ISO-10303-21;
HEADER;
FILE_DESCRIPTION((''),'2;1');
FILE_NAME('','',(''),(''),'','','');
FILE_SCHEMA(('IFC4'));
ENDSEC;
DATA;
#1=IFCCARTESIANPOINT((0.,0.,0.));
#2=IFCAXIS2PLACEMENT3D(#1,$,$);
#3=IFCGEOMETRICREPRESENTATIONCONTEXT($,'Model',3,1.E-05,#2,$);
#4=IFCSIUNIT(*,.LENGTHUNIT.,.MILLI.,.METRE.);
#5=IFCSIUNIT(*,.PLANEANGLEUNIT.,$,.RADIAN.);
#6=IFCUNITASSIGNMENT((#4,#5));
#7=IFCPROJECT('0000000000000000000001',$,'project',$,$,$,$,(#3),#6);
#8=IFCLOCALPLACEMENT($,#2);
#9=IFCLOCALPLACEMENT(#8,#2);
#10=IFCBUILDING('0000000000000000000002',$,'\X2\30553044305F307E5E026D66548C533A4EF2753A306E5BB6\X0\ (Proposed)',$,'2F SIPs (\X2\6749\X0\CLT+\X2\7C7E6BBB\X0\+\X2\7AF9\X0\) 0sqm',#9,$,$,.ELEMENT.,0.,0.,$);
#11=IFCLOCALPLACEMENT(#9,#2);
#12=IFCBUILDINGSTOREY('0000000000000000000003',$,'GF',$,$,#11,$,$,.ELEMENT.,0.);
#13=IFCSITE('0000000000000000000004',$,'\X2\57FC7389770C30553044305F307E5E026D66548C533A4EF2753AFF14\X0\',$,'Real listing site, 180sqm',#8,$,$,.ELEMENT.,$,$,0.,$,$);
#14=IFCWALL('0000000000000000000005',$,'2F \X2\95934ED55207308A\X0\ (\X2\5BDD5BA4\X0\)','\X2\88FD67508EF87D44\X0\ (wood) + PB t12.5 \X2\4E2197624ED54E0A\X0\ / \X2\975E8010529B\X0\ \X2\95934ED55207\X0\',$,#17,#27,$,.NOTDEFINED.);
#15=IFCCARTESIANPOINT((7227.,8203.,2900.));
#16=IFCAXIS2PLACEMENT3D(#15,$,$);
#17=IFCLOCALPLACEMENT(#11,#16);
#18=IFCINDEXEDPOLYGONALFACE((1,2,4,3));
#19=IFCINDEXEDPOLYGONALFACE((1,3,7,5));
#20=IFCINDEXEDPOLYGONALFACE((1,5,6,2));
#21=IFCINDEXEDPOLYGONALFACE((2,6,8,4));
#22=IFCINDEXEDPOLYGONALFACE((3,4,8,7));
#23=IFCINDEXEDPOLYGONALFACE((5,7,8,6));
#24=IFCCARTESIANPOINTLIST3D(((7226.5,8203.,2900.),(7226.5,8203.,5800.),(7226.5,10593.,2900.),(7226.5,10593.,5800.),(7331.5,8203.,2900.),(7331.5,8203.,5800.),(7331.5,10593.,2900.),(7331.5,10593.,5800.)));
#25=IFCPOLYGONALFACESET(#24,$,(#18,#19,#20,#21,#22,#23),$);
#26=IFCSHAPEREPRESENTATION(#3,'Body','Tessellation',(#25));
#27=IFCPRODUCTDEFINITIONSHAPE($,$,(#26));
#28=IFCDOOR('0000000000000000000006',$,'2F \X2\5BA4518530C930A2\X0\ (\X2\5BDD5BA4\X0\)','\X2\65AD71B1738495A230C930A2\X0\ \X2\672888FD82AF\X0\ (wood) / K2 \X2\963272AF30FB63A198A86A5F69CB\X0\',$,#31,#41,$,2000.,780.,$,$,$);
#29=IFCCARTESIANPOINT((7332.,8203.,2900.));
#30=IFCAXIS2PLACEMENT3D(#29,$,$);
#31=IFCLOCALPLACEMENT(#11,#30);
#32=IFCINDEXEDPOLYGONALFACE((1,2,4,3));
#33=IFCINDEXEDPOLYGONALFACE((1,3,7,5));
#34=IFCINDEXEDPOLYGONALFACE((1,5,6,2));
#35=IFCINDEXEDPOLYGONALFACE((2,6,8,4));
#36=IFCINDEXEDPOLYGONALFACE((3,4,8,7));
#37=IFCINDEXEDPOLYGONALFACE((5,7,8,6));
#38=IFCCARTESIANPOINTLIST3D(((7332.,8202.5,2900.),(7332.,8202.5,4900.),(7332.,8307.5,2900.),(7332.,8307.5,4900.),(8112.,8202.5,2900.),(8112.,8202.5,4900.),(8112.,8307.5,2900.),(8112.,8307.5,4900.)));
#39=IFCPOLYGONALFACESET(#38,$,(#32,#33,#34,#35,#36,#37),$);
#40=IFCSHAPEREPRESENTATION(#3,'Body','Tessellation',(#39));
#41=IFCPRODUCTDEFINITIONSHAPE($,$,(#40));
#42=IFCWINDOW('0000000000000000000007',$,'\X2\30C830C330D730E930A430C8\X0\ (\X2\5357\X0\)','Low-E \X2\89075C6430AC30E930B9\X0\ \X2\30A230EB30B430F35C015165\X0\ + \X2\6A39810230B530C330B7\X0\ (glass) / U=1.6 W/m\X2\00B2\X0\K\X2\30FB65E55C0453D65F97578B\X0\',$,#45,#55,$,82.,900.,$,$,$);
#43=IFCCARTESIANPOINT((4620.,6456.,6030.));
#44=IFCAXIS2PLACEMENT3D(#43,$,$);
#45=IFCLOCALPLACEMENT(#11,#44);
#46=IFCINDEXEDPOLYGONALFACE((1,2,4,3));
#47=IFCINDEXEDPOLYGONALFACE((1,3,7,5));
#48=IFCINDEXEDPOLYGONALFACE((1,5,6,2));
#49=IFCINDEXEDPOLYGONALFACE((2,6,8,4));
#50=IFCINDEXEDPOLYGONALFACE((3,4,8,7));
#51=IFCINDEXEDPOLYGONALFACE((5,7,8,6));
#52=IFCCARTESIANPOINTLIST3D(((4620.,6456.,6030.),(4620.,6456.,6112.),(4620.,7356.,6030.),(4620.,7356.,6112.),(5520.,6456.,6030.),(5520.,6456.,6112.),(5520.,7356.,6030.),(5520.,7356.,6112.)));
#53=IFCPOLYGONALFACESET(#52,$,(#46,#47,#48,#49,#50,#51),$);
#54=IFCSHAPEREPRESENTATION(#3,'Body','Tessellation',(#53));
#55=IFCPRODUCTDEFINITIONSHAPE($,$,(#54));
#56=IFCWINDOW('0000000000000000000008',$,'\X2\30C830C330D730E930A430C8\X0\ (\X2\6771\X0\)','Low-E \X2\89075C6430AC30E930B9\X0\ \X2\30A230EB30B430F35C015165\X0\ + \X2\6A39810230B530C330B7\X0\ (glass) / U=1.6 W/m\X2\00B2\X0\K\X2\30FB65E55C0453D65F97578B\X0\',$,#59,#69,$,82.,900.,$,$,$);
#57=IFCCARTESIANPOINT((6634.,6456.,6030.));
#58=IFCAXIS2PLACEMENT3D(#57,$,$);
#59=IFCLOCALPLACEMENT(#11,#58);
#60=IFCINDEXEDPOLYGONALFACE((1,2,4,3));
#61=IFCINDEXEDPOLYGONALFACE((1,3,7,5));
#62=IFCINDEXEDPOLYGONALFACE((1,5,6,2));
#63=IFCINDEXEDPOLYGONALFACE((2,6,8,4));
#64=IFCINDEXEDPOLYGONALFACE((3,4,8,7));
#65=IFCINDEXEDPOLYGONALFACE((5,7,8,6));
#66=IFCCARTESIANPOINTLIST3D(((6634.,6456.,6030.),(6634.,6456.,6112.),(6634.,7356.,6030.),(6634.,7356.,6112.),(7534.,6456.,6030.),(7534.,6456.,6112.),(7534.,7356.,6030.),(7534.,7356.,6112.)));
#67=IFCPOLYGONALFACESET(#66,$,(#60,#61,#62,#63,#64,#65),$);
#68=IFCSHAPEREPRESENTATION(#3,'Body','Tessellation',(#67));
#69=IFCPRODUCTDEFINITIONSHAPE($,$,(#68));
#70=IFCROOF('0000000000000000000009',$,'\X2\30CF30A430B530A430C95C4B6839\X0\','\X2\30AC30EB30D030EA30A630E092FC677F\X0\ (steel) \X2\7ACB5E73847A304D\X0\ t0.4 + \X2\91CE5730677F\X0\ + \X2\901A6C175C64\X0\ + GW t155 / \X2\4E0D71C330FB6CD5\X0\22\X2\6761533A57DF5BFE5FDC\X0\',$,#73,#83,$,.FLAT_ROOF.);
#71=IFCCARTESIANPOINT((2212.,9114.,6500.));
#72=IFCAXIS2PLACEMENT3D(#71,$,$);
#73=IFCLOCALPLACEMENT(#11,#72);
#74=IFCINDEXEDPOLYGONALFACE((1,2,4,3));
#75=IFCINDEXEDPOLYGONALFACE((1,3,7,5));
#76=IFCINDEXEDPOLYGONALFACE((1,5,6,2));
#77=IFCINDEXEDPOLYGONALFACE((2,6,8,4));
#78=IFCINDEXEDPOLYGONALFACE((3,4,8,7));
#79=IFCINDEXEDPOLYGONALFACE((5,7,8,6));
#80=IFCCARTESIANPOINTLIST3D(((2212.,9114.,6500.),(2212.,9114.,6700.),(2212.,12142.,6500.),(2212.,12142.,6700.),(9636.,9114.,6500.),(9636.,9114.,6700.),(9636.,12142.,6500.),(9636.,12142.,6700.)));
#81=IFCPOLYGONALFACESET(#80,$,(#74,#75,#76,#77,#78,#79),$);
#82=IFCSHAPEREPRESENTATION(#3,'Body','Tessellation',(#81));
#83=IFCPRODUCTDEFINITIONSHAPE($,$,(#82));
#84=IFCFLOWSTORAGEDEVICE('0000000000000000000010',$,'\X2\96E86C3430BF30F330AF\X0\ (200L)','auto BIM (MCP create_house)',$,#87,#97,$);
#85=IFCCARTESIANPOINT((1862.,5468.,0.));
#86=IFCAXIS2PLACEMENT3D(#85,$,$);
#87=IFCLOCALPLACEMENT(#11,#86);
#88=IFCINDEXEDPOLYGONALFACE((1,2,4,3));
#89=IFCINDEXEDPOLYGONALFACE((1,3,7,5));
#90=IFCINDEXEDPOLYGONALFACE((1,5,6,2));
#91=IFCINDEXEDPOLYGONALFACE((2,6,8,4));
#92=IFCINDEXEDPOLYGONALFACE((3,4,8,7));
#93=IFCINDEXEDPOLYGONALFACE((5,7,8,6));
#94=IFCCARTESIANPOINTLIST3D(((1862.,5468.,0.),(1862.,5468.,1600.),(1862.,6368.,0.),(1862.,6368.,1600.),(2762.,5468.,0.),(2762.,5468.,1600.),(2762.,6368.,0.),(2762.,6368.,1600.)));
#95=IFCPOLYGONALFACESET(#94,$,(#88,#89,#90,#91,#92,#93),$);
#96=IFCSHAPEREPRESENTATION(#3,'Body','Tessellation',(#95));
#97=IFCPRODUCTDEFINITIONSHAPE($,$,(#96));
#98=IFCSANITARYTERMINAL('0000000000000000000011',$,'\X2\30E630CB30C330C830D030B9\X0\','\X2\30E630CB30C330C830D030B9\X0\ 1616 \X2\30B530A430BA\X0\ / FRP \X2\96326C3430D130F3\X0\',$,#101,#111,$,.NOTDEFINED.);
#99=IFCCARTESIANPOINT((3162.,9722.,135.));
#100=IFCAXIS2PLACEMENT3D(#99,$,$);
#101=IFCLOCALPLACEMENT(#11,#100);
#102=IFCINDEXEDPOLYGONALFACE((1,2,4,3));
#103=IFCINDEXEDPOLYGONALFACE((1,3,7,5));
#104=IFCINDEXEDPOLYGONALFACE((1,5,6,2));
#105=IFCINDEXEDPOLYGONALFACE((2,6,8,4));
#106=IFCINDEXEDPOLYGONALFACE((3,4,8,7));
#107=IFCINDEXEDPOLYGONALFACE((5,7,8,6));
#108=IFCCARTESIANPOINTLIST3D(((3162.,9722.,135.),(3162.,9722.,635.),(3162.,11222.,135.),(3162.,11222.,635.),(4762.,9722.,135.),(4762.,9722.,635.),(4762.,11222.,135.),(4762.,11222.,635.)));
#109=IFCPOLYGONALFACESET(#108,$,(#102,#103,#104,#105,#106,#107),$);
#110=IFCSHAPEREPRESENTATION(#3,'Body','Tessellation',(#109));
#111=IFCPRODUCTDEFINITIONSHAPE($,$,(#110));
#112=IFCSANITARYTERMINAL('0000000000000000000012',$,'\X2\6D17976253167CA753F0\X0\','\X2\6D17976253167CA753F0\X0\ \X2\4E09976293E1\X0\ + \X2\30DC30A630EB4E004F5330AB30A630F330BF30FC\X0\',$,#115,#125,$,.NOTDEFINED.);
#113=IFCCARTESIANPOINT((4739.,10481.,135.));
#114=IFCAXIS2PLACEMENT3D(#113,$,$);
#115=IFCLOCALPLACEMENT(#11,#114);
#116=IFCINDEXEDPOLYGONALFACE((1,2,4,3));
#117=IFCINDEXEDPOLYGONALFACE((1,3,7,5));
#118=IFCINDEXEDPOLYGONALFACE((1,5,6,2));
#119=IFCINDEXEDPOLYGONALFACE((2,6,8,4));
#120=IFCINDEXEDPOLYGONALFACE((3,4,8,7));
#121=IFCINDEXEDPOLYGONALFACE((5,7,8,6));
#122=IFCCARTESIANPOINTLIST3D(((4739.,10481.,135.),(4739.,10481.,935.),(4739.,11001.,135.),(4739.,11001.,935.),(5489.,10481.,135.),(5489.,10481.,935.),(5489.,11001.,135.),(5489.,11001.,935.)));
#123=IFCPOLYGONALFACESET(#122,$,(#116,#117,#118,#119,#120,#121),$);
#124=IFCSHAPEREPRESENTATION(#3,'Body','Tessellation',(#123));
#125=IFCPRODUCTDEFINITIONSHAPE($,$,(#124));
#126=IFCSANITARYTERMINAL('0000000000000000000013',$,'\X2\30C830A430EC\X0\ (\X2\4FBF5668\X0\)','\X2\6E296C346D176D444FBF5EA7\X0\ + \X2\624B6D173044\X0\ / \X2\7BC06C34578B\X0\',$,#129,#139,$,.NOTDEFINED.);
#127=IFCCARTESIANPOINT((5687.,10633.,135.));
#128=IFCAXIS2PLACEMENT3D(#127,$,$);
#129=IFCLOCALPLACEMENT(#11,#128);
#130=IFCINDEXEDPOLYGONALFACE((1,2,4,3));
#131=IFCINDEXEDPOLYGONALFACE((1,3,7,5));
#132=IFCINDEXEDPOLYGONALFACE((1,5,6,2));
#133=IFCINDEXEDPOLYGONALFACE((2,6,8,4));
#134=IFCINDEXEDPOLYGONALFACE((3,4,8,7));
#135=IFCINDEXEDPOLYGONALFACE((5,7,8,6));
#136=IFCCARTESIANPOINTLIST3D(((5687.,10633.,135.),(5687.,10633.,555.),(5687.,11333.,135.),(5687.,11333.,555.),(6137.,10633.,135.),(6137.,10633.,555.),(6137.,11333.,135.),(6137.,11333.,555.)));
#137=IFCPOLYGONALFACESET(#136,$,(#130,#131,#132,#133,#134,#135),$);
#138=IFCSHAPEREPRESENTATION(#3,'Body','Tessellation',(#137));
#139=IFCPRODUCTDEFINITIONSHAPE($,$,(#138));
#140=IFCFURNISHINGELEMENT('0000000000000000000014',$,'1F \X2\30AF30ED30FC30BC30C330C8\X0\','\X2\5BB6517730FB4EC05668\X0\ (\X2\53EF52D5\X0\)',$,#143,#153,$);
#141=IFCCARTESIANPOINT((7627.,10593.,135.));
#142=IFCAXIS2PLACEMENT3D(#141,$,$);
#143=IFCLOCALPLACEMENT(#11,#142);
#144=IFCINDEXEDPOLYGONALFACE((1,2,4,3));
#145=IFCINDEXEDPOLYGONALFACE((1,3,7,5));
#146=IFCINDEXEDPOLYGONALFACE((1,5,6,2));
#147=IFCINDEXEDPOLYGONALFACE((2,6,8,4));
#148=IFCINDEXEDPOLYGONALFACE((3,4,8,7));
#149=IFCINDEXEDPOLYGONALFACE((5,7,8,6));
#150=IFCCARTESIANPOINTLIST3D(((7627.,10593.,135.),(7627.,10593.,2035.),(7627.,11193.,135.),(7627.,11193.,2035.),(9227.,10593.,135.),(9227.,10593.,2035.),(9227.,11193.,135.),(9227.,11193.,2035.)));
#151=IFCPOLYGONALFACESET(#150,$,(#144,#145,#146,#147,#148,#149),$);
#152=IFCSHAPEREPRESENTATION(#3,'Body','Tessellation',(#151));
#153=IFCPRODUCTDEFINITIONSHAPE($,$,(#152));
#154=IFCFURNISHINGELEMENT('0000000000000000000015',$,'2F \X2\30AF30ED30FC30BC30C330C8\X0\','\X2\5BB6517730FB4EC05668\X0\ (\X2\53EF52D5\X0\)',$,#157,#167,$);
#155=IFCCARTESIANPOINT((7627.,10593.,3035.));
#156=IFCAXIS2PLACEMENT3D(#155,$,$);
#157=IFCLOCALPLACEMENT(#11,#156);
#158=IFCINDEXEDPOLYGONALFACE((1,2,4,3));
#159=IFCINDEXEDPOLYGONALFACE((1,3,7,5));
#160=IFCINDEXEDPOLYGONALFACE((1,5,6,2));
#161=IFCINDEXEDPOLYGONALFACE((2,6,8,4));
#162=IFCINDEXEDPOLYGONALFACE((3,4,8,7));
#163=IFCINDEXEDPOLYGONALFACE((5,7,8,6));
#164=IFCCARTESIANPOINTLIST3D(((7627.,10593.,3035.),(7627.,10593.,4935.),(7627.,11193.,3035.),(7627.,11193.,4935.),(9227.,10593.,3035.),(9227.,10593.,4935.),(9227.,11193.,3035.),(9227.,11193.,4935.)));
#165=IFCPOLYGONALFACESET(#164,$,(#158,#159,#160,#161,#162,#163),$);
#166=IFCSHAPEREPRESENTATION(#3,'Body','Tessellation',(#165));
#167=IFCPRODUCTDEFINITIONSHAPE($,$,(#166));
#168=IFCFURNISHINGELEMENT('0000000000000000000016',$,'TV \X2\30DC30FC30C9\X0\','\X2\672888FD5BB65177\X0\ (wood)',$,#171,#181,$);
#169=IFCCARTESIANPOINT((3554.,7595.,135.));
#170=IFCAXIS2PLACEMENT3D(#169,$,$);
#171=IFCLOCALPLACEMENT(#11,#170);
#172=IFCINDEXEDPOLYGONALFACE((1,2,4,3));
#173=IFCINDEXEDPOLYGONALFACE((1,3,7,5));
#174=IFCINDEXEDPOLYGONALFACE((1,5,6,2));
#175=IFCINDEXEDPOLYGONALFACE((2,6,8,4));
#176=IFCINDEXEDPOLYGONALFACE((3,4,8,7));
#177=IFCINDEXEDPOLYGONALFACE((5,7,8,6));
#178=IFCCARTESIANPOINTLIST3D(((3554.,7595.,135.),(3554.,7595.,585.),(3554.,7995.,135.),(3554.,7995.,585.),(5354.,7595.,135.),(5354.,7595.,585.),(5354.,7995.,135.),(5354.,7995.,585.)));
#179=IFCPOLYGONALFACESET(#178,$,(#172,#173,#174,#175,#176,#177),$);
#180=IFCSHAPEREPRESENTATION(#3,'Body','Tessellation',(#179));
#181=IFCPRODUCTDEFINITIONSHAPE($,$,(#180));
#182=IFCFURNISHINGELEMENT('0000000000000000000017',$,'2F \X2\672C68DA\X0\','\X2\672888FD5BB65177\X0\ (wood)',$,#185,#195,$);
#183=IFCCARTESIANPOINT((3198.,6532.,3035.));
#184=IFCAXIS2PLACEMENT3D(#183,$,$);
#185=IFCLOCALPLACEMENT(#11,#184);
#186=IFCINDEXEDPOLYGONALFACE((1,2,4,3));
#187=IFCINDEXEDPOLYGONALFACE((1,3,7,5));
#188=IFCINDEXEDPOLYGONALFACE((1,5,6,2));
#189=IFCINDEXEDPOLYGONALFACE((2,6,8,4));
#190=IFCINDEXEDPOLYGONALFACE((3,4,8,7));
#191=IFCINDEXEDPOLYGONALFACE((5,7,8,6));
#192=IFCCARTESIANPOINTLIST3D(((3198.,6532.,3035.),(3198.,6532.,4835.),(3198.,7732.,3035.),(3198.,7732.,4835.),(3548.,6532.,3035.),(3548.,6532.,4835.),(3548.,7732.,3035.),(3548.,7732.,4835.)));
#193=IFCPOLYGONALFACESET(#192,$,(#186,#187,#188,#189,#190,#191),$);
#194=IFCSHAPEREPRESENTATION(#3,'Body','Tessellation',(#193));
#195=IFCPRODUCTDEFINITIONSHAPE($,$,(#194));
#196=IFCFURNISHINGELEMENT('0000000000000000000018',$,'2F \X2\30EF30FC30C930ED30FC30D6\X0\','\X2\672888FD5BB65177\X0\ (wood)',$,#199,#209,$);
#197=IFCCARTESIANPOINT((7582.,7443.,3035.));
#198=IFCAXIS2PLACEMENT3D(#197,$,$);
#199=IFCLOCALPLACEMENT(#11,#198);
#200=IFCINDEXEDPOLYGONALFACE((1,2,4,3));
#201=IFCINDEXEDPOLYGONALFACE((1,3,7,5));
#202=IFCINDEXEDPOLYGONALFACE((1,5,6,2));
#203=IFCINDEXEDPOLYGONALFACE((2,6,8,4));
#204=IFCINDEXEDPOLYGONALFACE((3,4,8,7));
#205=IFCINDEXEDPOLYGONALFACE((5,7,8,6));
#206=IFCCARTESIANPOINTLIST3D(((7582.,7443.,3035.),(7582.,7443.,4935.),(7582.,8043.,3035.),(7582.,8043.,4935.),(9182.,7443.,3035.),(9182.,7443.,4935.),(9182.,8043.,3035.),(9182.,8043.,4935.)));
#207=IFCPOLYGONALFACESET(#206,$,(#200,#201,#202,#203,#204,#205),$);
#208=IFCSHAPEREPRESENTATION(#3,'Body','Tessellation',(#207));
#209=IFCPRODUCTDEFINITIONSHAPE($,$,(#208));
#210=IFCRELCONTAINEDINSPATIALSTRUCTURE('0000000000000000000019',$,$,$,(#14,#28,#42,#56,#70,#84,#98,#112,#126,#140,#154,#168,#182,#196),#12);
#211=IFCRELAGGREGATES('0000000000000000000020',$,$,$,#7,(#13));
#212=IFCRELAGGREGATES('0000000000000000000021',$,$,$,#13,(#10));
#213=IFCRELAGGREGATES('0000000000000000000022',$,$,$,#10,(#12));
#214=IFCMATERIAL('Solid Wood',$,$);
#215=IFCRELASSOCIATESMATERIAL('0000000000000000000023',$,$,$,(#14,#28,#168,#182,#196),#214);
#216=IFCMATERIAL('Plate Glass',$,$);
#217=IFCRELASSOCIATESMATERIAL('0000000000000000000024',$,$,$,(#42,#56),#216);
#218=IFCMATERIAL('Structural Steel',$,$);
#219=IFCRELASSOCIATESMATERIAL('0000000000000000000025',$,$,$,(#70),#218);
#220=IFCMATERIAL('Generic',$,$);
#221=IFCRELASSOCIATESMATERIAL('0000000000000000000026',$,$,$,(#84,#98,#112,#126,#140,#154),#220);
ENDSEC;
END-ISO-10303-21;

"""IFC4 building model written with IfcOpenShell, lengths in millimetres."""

from ifc_helpers import new_model, si_unit, frame, frame_2d, origin, place, context, project, spatial, rectangle, extrude, material, element, save


model = new_model("IFC4")

# Units and contexts
model_context = context("Model", 3, precision=1e-05, world=origin())
ifc_project = project(units=[si_unit("LENGTHUNIT", "METRE", prefix="MILLI"), si_unit("PLANEANGLEUNIT", "RADIAN")], contexts=[model_context])

# Site, building, storey
site_placement = place(None, origin())
site = spatial("IfcSite", under=ifc_project, at=site_placement, Name="埼玉県さいたま市浦和区仲町４", ObjectType="Real listing site, 180sqm", CompositionType="ELEMENT", RefElevation=0.0)
building_placement = place(site_placement, origin())
building = spatial("IfcBuilding", under=site, at=building_placement, Name="さいたま市浦和区仲町の家 (Proposed)", ObjectType="2F SIPs (杉CLT+籾殻+竹) 0sqm", CompositionType="ELEMENT", ElevationOfRefHeight=0.0, ElevationOfTerrain=0.0)
storey_placement = place(building_placement, origin())
storey = spatial("IfcBuildingStorey", under=building, at=storey_placement, Name="GF", CompositionType="ELEMENT", Elevation=0.0)

# Shared definitions
ifc_material_1 = material(Name="Solid Wood")
ifc_material_2 = material(Name="Plate Glass")

# Wall
wall_1_placement = place(storey_placement, frame((7227.0, 8203.0, 2900.0)))
element("IfcWall", 1, at=wall_1_placement, inside=storey, material=ifc_material_1, Name="2F 間仕切り (寝室)", Description="製材軸組 (wood) + PB t12.5 両面仕上 / 非耐力 間仕切", PredefinedType="NOTDEFINED", context=model_context, shape_type="SweptSolid", body=[
    extrude(rectangle(XDim=105.0, YDim=2390.0, at=frame_2d((52.0, 1195.0))), frame((7227.0, 8203.0, 2900.0)), (0.0, 0.0, 1.0), 2900.0),
])

# Door
door_1_placement = place(storey_placement, frame((7332.0, 8203.0, 2900.0)))
element("IfcDoor", 2, at=door_1_placement, inside=storey, material=ifc_material_1, Name="2F 室内ドア (寝室)", Description="断熱玄関ドア 木製芯 (wood) / K2 防犯・採風機構", OverallHeight=2000.0, OverallWidth=780.0, context=model_context, shape_type="SweptSolid", body=[
    extrude(rectangle(XDim=780.0, YDim=105.0, at=frame_2d((390.0, 52.0))), frame((7332.0, 8203.0, 2900.0)), (0.0, 0.0, 1.0), 2000.0),
])

# Windows
window_1_placement = place(storey_placement, frame((4620.0, 6456.0, 6030.0)))
element("IfcWindow", 3, at=window_1_placement, inside=storey, material=ifc_material_2, Name="トップライト (南)", Description="Low-E 複層ガラス アルゴン封入 + 樹脂サッシ (glass) / U=1.6 W/m²K・日射取得型", OverallHeight=82.0, OverallWidth=900.0, context=model_context, shape_type="SweptSolid", body=[
    extrude(rectangle(XDim=900.0, YDim=900.0, at=frame_2d((450.0, 450.0))), frame((4620.0, 6456.0, 6030.0)), (0.0, 0.0, 1.0), 82.0),
])
window_2_placement = place(storey_placement, frame((6634.0, 6456.0, 6030.0)))
element("IfcWindow", 4, at=window_2_placement, inside=storey, material=ifc_material_2, Name="トップライト (東)", Description="Low-E 複層ガラス アルゴン封入 + 樹脂サッシ (glass) / U=1.6 W/m²K・日射取得型", OverallHeight=82.0, OverallWidth=900.0, context=model_context, shape_type="SweptSolid", body=[
    extrude(rectangle(XDim=900.0, YDim=900.0, at=frame_2d((450.0, 450.0))), frame((6634.0, 6456.0, 6030.0)), (0.0, 0.0, 1.0), 82.0),
])

# Roof
ifc_material_3 = material(Name="Structural Steel")
roof_placement = place(storey_placement, frame((2212.0, 9114.0, 6500.0)))
element("IfcRoof", 5, at=roof_placement, inside=storey, material=ifc_material_3, Name="ハイサイド屋根", Description="ガルバリウム鋼板 (steel) 立平葺き t0.4 + 野地板 + 通気層 + GW t155 / 不燃・法22条区域対応", PredefinedType="FLAT_ROOF", context=model_context, shape_type="SweptSolid", body=[
    extrude(rectangle(XDim=7424.0, YDim=3028.0, at=frame_2d((3712.0, 1514.0))), frame((2212.0, 9114.0, 6500.0)), (0.0, 0.0, 1.0), 200.0),
])

# Flow storage device
ifc_material_4 = material(Name="Generic")
flow_storage_device_placement = place(storey_placement, frame((1862.0, 5468.0, 0.0)))
element("IfcFlowStorageDevice", 6, at=flow_storage_device_placement, inside=storey, material=ifc_material_4, Name="雨水タンク (200L)", Description="auto BIM (MCP create_house)", context=model_context, shape_type="SweptSolid", body=[
    extrude(rectangle(XDim=900.0, YDim=900.0, at=frame_2d((450.0, 450.0))), frame((1862.0, 5468.0, 0.0)), (0.0, 0.0, 1.0), 1600.0),
])

# Sanitary terminals
sanitary_terminal_1_placement = place(storey_placement, frame((3162.0, 9722.0, 135.0)))
element("IfcSanitaryTerminal", 7, at=sanitary_terminal_1_placement, inside=storey, material=ifc_material_4, Name="ユニットバス", Description="ユニットバス 1616 サイズ / FRP 防水パン", PredefinedType="NOTDEFINED", context=model_context, shape_type="SweptSolid", body=[
    extrude(rectangle(XDim=1600.0, YDim=1500.0, at=frame_2d((800.0, 750.0))), frame((3162.0, 9722.0, 135.0)), (0.0, 0.0, 1.0), 500.0),
])
sanitary_terminal_2_placement = place(storey_placement, frame((4739.0, 10481.0, 135.0)))
element("IfcSanitaryTerminal", 8, at=sanitary_terminal_2_placement, inside=storey, material=ifc_material_4, Name="洗面化粧台", Description="洗面化粧台 三面鏡 + ボウル一体カウンター", PredefinedType="NOTDEFINED", context=model_context, shape_type="SweptSolid", body=[
    extrude(rectangle(XDim=750.0, YDim=520.0, at=frame_2d((375.0, 260.0))), frame((4739.0, 10481.0, 135.0)), (0.0, 0.0, 1.0), 800.0),
])
sanitary_terminal_3_placement = place(storey_placement, frame((5687.0, 10633.0, 135.0)))
element("IfcSanitaryTerminal", 9, at=sanitary_terminal_3_placement, inside=storey, material=ifc_material_4, Name="トイレ (便器)", Description="温水洗浄便座 + 手洗い / 節水型", PredefinedType="NOTDEFINED", context=model_context, shape_type="SweptSolid", body=[
    extrude(rectangle(XDim=450.0, YDim=700.0, at=frame_2d((225.0, 350.0))), frame((5687.0, 10633.0, 135.0)), (0.0, 0.0, 1.0), 420.0),
])

# Furnishing elements
furnishing_1_placement = place(storey_placement, frame((7627.0, 10593.0, 135.0)))
element("IfcFurnishingElement", 10, at=furnishing_1_placement, inside=storey, material=ifc_material_4, Name="1F クローゼット", Description="家具・什器 (可動)", context=model_context, shape_type="SweptSolid", body=[
    extrude(rectangle(XDim=1600.0, YDim=600.0, at=frame_2d((800.0, 300.0))), frame((7627.0, 10593.0, 135.0)), (0.0, 0.0, 1.0), 1900.0),
])
furnishing_2_placement = place(storey_placement, frame((7627.0, 10593.0, 3035.0)))
element("IfcFurnishingElement", 11, at=furnishing_2_placement, inside=storey, material=ifc_material_4, Name="2F クローゼット", Description="家具・什器 (可動)", context=model_context, shape_type="SweptSolid", body=[
    extrude(rectangle(XDim=1600.0, YDim=600.0, at=frame_2d((800.0, 300.0))), frame((7627.0, 10593.0, 3035.0)), (0.0, 0.0, 1.0), 1900.0),
])
furnishing_3_placement = place(storey_placement, frame((3554.0, 7595.0, 135.0)))
element("IfcFurnishingElement", 12, at=furnishing_3_placement, inside=storey, material=ifc_material_1, Name="TV ボード", Description="木製家具 (wood)", context=model_context, shape_type="SweptSolid", body=[
    extrude(rectangle(XDim=1800.0, YDim=400.0, at=frame_2d((900.0, 200.0))), frame((3554.0, 7595.0, 135.0)), (0.0, 0.0, 1.0), 450.0),
])
furnishing_4_placement = place(storey_placement, frame((3198.0, 6532.0, 3035.0)))
element("IfcFurnishingElement", 13, at=furnishing_4_placement, inside=storey, material=ifc_material_1, Name="2F 本棚", Description="木製家具 (wood)", context=model_context, shape_type="SweptSolid", body=[
    extrude(rectangle(XDim=350.0, YDim=1200.0, at=frame_2d((175.0, 600.0))), frame((3198.0, 6532.0, 3035.0)), (0.0, 0.0, 1.0), 1800.0),
])
furnishing_5_placement = place(storey_placement, frame((7582.0, 7443.0, 3035.0)))
element("IfcFurnishingElement", 14, at=furnishing_5_placement, inside=storey, material=ifc_material_1, Name="2F ワードローブ", Description="木製家具 (wood)", context=model_context, shape_type="SweptSolid", body=[
    extrude(rectangle(XDim=1600.0, YDim=600.0, at=frame_2d((800.0, 300.0))), frame((7582.0, 7443.0, 3035.0)), (0.0, 0.0, 1.0), 1900.0),
])

save(model, "model.ifc")
